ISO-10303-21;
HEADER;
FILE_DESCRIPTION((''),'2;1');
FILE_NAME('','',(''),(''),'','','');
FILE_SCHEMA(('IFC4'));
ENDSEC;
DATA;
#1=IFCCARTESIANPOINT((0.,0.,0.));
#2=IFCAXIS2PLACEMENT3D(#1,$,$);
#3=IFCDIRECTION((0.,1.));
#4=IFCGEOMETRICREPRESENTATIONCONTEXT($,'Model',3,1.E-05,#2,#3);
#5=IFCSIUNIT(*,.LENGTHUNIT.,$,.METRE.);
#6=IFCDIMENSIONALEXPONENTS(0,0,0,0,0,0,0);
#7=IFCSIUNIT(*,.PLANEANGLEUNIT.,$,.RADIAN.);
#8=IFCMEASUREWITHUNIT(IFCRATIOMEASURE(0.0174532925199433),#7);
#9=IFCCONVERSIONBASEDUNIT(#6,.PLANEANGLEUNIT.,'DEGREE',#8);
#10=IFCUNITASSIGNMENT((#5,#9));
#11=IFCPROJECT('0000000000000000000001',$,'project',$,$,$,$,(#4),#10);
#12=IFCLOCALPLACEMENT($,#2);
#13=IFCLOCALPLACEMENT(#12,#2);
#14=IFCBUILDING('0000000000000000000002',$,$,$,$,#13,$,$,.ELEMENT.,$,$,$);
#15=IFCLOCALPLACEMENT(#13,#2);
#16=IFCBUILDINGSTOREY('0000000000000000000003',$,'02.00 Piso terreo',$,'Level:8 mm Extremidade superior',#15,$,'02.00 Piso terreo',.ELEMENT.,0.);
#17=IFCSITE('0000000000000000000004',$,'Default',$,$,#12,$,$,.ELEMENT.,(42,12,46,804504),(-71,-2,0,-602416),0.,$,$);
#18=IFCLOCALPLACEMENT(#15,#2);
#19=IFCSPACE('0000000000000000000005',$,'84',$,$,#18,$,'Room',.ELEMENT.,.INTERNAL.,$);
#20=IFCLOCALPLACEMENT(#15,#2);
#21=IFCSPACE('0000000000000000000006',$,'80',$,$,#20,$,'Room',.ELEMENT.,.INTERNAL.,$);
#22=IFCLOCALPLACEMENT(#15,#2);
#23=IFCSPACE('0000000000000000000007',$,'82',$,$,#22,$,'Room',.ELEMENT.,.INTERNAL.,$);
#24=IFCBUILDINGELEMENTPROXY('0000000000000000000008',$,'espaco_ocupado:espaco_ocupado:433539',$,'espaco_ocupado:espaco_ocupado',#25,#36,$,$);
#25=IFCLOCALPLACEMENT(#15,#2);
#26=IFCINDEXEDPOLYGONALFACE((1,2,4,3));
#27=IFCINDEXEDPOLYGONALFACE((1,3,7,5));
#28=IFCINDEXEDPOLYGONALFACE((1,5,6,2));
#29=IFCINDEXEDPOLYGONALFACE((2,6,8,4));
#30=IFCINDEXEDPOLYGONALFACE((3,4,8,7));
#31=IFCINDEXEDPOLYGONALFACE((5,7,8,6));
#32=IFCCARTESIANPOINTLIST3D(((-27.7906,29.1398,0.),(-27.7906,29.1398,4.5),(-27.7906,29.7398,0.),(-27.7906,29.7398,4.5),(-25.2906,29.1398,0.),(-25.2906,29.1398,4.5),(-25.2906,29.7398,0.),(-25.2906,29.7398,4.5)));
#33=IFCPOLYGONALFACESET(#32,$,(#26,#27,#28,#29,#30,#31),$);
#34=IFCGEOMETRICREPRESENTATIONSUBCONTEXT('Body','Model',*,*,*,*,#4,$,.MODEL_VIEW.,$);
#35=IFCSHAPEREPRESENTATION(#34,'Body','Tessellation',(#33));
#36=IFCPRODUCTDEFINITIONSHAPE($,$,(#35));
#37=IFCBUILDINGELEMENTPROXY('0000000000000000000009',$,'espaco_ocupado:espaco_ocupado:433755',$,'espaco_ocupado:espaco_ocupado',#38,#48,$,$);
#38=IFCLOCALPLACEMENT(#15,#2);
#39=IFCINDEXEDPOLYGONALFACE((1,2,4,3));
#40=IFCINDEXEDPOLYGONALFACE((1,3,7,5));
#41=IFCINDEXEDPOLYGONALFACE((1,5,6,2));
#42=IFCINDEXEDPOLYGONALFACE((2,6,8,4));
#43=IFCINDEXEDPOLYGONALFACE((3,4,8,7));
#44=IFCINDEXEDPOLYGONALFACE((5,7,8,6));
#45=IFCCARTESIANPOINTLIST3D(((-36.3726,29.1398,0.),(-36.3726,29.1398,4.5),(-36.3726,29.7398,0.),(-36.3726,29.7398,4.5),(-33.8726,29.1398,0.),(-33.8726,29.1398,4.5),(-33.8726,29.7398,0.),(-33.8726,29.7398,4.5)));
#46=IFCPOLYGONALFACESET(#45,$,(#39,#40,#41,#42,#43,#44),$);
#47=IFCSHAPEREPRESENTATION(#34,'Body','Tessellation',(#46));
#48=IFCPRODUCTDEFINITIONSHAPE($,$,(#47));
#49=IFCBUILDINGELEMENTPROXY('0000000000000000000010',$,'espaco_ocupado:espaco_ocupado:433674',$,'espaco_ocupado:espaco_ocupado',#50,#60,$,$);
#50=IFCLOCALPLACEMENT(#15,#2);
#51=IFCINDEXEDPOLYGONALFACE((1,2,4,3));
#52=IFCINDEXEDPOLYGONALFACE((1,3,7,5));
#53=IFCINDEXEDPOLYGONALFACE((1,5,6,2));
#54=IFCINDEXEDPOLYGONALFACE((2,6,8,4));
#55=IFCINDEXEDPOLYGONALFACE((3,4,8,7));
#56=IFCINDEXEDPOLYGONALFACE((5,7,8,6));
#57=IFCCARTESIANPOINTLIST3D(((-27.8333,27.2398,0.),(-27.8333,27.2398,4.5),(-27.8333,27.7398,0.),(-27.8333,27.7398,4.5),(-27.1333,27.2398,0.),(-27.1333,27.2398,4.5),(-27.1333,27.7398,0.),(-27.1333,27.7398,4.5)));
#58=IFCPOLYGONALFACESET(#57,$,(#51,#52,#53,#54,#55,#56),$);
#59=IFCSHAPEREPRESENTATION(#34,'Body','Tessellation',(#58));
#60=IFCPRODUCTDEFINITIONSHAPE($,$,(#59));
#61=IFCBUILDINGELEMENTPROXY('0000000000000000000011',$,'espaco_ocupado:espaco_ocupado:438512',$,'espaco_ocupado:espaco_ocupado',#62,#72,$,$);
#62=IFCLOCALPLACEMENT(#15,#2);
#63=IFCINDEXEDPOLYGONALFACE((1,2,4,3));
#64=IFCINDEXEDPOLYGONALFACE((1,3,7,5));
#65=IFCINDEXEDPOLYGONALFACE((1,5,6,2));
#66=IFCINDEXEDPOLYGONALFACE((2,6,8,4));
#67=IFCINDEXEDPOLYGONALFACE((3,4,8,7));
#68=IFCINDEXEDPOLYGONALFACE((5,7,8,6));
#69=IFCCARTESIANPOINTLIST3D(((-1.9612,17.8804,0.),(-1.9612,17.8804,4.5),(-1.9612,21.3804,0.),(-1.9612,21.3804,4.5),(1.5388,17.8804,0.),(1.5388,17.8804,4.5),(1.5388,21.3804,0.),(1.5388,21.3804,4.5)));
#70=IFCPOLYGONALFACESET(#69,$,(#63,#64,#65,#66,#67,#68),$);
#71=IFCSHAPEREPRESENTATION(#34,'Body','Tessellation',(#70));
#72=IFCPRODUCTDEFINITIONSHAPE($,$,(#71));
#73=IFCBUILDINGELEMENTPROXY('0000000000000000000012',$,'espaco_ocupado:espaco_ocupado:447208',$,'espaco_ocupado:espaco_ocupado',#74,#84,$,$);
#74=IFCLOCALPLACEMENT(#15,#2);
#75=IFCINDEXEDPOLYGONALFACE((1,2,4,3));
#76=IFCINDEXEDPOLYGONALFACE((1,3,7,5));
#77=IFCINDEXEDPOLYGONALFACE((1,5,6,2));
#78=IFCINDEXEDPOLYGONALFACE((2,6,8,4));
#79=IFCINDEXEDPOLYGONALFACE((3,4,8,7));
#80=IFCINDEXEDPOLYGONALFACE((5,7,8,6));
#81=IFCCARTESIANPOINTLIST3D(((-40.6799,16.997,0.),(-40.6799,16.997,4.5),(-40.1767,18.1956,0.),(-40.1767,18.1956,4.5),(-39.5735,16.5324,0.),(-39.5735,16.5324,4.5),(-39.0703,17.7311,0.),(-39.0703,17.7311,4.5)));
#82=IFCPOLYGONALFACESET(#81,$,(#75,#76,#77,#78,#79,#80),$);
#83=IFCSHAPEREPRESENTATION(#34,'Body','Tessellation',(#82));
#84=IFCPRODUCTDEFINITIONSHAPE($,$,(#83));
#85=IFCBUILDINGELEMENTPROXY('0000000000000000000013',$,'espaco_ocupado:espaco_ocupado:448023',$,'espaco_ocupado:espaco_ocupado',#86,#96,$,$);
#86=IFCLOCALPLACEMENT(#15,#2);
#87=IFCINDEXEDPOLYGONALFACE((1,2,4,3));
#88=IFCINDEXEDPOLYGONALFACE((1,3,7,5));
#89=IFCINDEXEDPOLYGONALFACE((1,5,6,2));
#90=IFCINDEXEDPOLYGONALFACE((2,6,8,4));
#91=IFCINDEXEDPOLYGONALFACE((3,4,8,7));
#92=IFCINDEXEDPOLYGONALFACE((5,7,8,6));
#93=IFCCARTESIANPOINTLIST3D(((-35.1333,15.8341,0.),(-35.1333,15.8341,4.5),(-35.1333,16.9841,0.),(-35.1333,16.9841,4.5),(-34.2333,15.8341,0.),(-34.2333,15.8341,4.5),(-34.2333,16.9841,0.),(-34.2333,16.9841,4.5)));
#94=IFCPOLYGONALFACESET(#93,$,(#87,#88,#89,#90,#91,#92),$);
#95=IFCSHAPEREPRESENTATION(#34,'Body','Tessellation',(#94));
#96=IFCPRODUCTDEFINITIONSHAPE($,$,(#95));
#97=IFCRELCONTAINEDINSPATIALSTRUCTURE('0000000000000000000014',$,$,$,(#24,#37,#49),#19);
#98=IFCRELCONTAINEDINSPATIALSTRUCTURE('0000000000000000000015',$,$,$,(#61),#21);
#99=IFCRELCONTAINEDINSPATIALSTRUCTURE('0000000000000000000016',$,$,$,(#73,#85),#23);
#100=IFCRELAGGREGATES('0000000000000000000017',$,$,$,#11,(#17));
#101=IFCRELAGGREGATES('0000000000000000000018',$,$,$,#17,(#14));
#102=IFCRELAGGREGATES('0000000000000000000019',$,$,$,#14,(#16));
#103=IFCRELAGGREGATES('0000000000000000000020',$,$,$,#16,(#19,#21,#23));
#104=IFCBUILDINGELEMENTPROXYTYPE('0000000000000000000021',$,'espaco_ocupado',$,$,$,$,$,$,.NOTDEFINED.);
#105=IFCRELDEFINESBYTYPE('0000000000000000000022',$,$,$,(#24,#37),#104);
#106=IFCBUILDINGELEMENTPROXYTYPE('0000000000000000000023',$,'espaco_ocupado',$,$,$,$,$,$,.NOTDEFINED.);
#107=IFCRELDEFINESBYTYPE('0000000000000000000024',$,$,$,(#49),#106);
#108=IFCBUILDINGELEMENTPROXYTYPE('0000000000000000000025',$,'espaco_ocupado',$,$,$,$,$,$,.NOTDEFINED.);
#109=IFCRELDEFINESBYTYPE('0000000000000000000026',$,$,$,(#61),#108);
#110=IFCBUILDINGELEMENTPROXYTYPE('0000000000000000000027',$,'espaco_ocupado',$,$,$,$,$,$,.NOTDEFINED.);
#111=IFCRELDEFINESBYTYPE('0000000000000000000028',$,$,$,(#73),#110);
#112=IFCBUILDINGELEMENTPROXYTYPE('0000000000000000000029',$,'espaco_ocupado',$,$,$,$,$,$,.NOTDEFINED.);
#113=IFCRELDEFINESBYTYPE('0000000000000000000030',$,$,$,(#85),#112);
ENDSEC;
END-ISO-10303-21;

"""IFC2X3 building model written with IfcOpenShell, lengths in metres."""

from ifc_helpers import new_model, entity, si_unit, converted_unit, direction, frame, origin, origin_2d_with_axis, place, context, subcontext, project, spatial, rectangle, extrude, source, transform, mapped, type_object, type_shapes, element, save


model = new_model("IFC2X3")

# Units and contexts
model_context = context("Model", 3, precision=1e-05, world=origin(), true_north=direction((0.0, 1.0)))
body_context = subcontext(model_context, "Body", "Model", "MODEL_VIEW")
ifc_project = project(units=[si_unit("LENGTHUNIT", "METRE"), converted_unit("PLANEANGLEUNIT", "DEGREE", entity("IfcRatioMeasure", 0.0174532925199433), si_unit("PLANEANGLEUNIT", "RADIAN"), dimensions=[0, 0, 0, 0, 0, 0, 0])], contexts=[model_context])

# Site, building, storey
site_placement = place(None, origin())
site = spatial("IfcSite", under=ifc_project, at=site_placement, Name="Default", CompositionType="ELEMENT", RefLatitude=(42, 12, 46, 804504), RefLongitude=(-71, -2, 0, -602416), RefElevation=0.0)
building_placement = place(site_placement, origin())
building = spatial("IfcBuilding", under=site, at=building_placement, CompositionType="ELEMENT")
storey_placement = place(building_placement, origin())
storey = spatial("IfcBuildingStorey", under=building, at=storey_placement, Name="02.00 Piso terreo", ObjectType="Level:8 mm Extremidade superior", LongName="02.00 Piso terreo", CompositionType="ELEMENT", Elevation=0.0)

# Shared definitions
space_1_placement = place(storey_placement, origin())
space_1 = spatial("IfcSpace", under=storey, at=space_1_placement, Name="84", LongName="Room", CompositionType="ELEMENT", InteriorOrExteriorSpace="INTERNAL")

# Shared definitions
space_2_placement = place(storey_placement, origin())
space_2 = spatial("IfcSpace", under=storey, at=space_2_placement, Name="80", LongName="Room", CompositionType="ELEMENT", InteriorOrExteriorSpace="INTERNAL")

# Building element proxies
building_element_proxy_type_1 = type_object("IfcBuildingElementProxyType", Name="espaco_ocupado", PredefinedType="NOTDEFINED")
shared_shape_1 = source(origin(), body_context, "Body", "SweptSolid", [
    extrude(rectangle(XDim=2.5, YDim=0.6, at=origin_2d_with_axis()), frame((0.0, 0.0, 0.0), z_axis=(0.0, 0.0, 1.0), x_axis=(-1.0, 0.0, 0.0)), (0.0, 0.0, 1.0), 4.5),
])
type_shapes(building_element_proxy_type_1, [shared_shape_1])
for number, where, name in (
    (1, (-26.5406, 29.4398, 0.0), "espaco_ocupado:espaco_ocupado:433539"),
    (2, (-35.1226, 29.4398, 0.0), "espaco_ocupado:espaco_ocupado:433755"),
):
    element("IfcBuildingElementProxy", number, at=place(space_1_placement, frame(where)), inside=space_1, type_object=building_element_proxy_type_1, Name=name, ObjectType="espaco_ocupado:espaco_ocupado", context=body_context, shape_type="MappedRepresentation", body=[
        mapped(shared_shape_1, transform((0.0, 0.0, 0.0), scale=1.0)),
    ])
building_element_proxy_type_2 = type_object("IfcBuildingElementProxyType", Name="espaco_ocupado", PredefinedType="NOTDEFINED")
shared_shape_2 = source(origin(), body_context, "Body", "SweptSolid", [
    extrude(rectangle(XDim=0.7, YDim=0.5, at=origin_2d_with_axis()), frame((0.0, 0.0, 0.0), z_axis=(0.0, 0.0, 1.0), x_axis=(-1.0, 0.0, 0.0)), (0.0, 0.0, 1.0), 4.5),
])
type_shapes(building_element_proxy_type_2, [shared_shape_2])
proxy_1_placement = place(space_1_placement, frame((-27.4833, 27.4898, 0.0)))
element("IfcBuildingElementProxy", 3, at=proxy_1_placement, inside=space_1, type_object=building_element_proxy_type_2, Name="espaco_ocupado:espaco_ocupado:433674", ObjectType="espaco_ocupado:espaco_ocupado", context=body_context, shape_type="MappedRepresentation", body=[
    mapped(shared_shape_2, transform((0.0, 0.0, 0.0), scale=1.0)),
])
building_element_proxy_type_3 = type_object("IfcBuildingElementProxyType", Name="espaco_ocupado", PredefinedType="NOTDEFINED")
shared_shape_3 = source(origin(), body_context, "Body", "SweptSolid", [
    extrude(rectangle(XDim=3.5, YDim=3.5, at=origin_2d_with_axis()), frame((0.0, 0.0, 0.0), z_axis=(0.0, 0.0, 1.0), x_axis=(-1.0, 0.0, 0.0)), (0.0, 0.0, 1.0), 4.5),
])
type_shapes(building_element_proxy_type_3, [shared_shape_3])
proxy_2_placement = place(space_2_placement, frame((-0.2112, 19.6304, 0.0)))
element("IfcBuildingElementProxy", 4, at=proxy_2_placement, inside=space_2, type_object=building_element_proxy_type_3, Name="espaco_ocupado:espaco_ocupado:438512", ObjectType="espaco_ocupado:espaco_ocupado", context=body_context, shape_type="MappedRepresentation", body=[
    mapped(shared_shape_3, transform((0.0, 0.0, 0.0), scale=1.0)),
])

# Shared definitions
space_3_placement = place(storey_placement, origin())
space_3 = spatial("IfcSpace", under=storey, at=space_3_placement, Name="82", LongName="Room", CompositionType="ELEMENT", InteriorOrExteriorSpace="INTERNAL")

# Building element proxies
building_element_proxy_type_4 = type_object("IfcBuildingElementProxyType", Name="espaco_ocupado", PredefinedType="NOTDEFINED")
shared_shape_4 = source(origin(), body_context, "Body", "SweptSolid", [
    extrude(rectangle(XDim=1.3, YDim=1.2, at=origin_2d_with_axis()), frame((0.0, 0.0, 0.0), z_axis=(0.0, 0.0, 1.0), x_axis=(-1.0, 0.0, 0.0)), (0.0, 0.0, 1.0), 4.5),
])
type_shapes(building_element_proxy_type_4, [shared_shape_4])
proxy_3_placement = place(space_3_placement, frame((-39.8751, 17.364, 0.0), z_axis=(0.0, 0.0, 1.0), x_axis=(0.387097, 0.922039, 0.0)))
element("IfcBuildingElementProxy", 5, at=proxy_3_placement, inside=space_3, type_object=building_element_proxy_type_4, Name="espaco_ocupado:espaco_ocupado:447208", ObjectType="espaco_ocupado:espaco_ocupado", context=body_context, shape_type="MappedRepresentation", body=[
    mapped(shared_shape_4, transform((0.0, 0.0, 0.0), scale=1.0)),
])
building_element_proxy_type_5 = type_object("IfcBuildingElementProxyType", Name="espaco_ocupado", PredefinedType="NOTDEFINED")
shared_shape_5 = source(origin(), body_context, "Body", "SweptSolid", [
    extrude(rectangle(XDim=0.9, YDim=1.15, at=origin_2d_with_axis()), frame((0.0, 0.0, 0.0), z_axis=(0.0, 0.0, 1.0), x_axis=(-1.0, 0.0, 0.0)), (0.0, 0.0, 1.0), 4.5),
])
type_shapes(building_element_proxy_type_5, [shared_shape_5])
proxy_4_placement = place(space_3_placement, frame((-34.6833, 16.4091, 0.0)))
element("IfcBuildingElementProxy", 6, at=proxy_4_placement, inside=space_3, type_object=building_element_proxy_type_5, Name="espaco_ocupado:espaco_ocupado:448023", ObjectType="espaco_ocupado:espaco_ocupado", context=body_context, shape_type="MappedRepresentation", body=[
    mapped(shared_shape_5, transform((0.0, 0.0, 0.0), scale=1.0)),
])

save(model, "model.ifc")
